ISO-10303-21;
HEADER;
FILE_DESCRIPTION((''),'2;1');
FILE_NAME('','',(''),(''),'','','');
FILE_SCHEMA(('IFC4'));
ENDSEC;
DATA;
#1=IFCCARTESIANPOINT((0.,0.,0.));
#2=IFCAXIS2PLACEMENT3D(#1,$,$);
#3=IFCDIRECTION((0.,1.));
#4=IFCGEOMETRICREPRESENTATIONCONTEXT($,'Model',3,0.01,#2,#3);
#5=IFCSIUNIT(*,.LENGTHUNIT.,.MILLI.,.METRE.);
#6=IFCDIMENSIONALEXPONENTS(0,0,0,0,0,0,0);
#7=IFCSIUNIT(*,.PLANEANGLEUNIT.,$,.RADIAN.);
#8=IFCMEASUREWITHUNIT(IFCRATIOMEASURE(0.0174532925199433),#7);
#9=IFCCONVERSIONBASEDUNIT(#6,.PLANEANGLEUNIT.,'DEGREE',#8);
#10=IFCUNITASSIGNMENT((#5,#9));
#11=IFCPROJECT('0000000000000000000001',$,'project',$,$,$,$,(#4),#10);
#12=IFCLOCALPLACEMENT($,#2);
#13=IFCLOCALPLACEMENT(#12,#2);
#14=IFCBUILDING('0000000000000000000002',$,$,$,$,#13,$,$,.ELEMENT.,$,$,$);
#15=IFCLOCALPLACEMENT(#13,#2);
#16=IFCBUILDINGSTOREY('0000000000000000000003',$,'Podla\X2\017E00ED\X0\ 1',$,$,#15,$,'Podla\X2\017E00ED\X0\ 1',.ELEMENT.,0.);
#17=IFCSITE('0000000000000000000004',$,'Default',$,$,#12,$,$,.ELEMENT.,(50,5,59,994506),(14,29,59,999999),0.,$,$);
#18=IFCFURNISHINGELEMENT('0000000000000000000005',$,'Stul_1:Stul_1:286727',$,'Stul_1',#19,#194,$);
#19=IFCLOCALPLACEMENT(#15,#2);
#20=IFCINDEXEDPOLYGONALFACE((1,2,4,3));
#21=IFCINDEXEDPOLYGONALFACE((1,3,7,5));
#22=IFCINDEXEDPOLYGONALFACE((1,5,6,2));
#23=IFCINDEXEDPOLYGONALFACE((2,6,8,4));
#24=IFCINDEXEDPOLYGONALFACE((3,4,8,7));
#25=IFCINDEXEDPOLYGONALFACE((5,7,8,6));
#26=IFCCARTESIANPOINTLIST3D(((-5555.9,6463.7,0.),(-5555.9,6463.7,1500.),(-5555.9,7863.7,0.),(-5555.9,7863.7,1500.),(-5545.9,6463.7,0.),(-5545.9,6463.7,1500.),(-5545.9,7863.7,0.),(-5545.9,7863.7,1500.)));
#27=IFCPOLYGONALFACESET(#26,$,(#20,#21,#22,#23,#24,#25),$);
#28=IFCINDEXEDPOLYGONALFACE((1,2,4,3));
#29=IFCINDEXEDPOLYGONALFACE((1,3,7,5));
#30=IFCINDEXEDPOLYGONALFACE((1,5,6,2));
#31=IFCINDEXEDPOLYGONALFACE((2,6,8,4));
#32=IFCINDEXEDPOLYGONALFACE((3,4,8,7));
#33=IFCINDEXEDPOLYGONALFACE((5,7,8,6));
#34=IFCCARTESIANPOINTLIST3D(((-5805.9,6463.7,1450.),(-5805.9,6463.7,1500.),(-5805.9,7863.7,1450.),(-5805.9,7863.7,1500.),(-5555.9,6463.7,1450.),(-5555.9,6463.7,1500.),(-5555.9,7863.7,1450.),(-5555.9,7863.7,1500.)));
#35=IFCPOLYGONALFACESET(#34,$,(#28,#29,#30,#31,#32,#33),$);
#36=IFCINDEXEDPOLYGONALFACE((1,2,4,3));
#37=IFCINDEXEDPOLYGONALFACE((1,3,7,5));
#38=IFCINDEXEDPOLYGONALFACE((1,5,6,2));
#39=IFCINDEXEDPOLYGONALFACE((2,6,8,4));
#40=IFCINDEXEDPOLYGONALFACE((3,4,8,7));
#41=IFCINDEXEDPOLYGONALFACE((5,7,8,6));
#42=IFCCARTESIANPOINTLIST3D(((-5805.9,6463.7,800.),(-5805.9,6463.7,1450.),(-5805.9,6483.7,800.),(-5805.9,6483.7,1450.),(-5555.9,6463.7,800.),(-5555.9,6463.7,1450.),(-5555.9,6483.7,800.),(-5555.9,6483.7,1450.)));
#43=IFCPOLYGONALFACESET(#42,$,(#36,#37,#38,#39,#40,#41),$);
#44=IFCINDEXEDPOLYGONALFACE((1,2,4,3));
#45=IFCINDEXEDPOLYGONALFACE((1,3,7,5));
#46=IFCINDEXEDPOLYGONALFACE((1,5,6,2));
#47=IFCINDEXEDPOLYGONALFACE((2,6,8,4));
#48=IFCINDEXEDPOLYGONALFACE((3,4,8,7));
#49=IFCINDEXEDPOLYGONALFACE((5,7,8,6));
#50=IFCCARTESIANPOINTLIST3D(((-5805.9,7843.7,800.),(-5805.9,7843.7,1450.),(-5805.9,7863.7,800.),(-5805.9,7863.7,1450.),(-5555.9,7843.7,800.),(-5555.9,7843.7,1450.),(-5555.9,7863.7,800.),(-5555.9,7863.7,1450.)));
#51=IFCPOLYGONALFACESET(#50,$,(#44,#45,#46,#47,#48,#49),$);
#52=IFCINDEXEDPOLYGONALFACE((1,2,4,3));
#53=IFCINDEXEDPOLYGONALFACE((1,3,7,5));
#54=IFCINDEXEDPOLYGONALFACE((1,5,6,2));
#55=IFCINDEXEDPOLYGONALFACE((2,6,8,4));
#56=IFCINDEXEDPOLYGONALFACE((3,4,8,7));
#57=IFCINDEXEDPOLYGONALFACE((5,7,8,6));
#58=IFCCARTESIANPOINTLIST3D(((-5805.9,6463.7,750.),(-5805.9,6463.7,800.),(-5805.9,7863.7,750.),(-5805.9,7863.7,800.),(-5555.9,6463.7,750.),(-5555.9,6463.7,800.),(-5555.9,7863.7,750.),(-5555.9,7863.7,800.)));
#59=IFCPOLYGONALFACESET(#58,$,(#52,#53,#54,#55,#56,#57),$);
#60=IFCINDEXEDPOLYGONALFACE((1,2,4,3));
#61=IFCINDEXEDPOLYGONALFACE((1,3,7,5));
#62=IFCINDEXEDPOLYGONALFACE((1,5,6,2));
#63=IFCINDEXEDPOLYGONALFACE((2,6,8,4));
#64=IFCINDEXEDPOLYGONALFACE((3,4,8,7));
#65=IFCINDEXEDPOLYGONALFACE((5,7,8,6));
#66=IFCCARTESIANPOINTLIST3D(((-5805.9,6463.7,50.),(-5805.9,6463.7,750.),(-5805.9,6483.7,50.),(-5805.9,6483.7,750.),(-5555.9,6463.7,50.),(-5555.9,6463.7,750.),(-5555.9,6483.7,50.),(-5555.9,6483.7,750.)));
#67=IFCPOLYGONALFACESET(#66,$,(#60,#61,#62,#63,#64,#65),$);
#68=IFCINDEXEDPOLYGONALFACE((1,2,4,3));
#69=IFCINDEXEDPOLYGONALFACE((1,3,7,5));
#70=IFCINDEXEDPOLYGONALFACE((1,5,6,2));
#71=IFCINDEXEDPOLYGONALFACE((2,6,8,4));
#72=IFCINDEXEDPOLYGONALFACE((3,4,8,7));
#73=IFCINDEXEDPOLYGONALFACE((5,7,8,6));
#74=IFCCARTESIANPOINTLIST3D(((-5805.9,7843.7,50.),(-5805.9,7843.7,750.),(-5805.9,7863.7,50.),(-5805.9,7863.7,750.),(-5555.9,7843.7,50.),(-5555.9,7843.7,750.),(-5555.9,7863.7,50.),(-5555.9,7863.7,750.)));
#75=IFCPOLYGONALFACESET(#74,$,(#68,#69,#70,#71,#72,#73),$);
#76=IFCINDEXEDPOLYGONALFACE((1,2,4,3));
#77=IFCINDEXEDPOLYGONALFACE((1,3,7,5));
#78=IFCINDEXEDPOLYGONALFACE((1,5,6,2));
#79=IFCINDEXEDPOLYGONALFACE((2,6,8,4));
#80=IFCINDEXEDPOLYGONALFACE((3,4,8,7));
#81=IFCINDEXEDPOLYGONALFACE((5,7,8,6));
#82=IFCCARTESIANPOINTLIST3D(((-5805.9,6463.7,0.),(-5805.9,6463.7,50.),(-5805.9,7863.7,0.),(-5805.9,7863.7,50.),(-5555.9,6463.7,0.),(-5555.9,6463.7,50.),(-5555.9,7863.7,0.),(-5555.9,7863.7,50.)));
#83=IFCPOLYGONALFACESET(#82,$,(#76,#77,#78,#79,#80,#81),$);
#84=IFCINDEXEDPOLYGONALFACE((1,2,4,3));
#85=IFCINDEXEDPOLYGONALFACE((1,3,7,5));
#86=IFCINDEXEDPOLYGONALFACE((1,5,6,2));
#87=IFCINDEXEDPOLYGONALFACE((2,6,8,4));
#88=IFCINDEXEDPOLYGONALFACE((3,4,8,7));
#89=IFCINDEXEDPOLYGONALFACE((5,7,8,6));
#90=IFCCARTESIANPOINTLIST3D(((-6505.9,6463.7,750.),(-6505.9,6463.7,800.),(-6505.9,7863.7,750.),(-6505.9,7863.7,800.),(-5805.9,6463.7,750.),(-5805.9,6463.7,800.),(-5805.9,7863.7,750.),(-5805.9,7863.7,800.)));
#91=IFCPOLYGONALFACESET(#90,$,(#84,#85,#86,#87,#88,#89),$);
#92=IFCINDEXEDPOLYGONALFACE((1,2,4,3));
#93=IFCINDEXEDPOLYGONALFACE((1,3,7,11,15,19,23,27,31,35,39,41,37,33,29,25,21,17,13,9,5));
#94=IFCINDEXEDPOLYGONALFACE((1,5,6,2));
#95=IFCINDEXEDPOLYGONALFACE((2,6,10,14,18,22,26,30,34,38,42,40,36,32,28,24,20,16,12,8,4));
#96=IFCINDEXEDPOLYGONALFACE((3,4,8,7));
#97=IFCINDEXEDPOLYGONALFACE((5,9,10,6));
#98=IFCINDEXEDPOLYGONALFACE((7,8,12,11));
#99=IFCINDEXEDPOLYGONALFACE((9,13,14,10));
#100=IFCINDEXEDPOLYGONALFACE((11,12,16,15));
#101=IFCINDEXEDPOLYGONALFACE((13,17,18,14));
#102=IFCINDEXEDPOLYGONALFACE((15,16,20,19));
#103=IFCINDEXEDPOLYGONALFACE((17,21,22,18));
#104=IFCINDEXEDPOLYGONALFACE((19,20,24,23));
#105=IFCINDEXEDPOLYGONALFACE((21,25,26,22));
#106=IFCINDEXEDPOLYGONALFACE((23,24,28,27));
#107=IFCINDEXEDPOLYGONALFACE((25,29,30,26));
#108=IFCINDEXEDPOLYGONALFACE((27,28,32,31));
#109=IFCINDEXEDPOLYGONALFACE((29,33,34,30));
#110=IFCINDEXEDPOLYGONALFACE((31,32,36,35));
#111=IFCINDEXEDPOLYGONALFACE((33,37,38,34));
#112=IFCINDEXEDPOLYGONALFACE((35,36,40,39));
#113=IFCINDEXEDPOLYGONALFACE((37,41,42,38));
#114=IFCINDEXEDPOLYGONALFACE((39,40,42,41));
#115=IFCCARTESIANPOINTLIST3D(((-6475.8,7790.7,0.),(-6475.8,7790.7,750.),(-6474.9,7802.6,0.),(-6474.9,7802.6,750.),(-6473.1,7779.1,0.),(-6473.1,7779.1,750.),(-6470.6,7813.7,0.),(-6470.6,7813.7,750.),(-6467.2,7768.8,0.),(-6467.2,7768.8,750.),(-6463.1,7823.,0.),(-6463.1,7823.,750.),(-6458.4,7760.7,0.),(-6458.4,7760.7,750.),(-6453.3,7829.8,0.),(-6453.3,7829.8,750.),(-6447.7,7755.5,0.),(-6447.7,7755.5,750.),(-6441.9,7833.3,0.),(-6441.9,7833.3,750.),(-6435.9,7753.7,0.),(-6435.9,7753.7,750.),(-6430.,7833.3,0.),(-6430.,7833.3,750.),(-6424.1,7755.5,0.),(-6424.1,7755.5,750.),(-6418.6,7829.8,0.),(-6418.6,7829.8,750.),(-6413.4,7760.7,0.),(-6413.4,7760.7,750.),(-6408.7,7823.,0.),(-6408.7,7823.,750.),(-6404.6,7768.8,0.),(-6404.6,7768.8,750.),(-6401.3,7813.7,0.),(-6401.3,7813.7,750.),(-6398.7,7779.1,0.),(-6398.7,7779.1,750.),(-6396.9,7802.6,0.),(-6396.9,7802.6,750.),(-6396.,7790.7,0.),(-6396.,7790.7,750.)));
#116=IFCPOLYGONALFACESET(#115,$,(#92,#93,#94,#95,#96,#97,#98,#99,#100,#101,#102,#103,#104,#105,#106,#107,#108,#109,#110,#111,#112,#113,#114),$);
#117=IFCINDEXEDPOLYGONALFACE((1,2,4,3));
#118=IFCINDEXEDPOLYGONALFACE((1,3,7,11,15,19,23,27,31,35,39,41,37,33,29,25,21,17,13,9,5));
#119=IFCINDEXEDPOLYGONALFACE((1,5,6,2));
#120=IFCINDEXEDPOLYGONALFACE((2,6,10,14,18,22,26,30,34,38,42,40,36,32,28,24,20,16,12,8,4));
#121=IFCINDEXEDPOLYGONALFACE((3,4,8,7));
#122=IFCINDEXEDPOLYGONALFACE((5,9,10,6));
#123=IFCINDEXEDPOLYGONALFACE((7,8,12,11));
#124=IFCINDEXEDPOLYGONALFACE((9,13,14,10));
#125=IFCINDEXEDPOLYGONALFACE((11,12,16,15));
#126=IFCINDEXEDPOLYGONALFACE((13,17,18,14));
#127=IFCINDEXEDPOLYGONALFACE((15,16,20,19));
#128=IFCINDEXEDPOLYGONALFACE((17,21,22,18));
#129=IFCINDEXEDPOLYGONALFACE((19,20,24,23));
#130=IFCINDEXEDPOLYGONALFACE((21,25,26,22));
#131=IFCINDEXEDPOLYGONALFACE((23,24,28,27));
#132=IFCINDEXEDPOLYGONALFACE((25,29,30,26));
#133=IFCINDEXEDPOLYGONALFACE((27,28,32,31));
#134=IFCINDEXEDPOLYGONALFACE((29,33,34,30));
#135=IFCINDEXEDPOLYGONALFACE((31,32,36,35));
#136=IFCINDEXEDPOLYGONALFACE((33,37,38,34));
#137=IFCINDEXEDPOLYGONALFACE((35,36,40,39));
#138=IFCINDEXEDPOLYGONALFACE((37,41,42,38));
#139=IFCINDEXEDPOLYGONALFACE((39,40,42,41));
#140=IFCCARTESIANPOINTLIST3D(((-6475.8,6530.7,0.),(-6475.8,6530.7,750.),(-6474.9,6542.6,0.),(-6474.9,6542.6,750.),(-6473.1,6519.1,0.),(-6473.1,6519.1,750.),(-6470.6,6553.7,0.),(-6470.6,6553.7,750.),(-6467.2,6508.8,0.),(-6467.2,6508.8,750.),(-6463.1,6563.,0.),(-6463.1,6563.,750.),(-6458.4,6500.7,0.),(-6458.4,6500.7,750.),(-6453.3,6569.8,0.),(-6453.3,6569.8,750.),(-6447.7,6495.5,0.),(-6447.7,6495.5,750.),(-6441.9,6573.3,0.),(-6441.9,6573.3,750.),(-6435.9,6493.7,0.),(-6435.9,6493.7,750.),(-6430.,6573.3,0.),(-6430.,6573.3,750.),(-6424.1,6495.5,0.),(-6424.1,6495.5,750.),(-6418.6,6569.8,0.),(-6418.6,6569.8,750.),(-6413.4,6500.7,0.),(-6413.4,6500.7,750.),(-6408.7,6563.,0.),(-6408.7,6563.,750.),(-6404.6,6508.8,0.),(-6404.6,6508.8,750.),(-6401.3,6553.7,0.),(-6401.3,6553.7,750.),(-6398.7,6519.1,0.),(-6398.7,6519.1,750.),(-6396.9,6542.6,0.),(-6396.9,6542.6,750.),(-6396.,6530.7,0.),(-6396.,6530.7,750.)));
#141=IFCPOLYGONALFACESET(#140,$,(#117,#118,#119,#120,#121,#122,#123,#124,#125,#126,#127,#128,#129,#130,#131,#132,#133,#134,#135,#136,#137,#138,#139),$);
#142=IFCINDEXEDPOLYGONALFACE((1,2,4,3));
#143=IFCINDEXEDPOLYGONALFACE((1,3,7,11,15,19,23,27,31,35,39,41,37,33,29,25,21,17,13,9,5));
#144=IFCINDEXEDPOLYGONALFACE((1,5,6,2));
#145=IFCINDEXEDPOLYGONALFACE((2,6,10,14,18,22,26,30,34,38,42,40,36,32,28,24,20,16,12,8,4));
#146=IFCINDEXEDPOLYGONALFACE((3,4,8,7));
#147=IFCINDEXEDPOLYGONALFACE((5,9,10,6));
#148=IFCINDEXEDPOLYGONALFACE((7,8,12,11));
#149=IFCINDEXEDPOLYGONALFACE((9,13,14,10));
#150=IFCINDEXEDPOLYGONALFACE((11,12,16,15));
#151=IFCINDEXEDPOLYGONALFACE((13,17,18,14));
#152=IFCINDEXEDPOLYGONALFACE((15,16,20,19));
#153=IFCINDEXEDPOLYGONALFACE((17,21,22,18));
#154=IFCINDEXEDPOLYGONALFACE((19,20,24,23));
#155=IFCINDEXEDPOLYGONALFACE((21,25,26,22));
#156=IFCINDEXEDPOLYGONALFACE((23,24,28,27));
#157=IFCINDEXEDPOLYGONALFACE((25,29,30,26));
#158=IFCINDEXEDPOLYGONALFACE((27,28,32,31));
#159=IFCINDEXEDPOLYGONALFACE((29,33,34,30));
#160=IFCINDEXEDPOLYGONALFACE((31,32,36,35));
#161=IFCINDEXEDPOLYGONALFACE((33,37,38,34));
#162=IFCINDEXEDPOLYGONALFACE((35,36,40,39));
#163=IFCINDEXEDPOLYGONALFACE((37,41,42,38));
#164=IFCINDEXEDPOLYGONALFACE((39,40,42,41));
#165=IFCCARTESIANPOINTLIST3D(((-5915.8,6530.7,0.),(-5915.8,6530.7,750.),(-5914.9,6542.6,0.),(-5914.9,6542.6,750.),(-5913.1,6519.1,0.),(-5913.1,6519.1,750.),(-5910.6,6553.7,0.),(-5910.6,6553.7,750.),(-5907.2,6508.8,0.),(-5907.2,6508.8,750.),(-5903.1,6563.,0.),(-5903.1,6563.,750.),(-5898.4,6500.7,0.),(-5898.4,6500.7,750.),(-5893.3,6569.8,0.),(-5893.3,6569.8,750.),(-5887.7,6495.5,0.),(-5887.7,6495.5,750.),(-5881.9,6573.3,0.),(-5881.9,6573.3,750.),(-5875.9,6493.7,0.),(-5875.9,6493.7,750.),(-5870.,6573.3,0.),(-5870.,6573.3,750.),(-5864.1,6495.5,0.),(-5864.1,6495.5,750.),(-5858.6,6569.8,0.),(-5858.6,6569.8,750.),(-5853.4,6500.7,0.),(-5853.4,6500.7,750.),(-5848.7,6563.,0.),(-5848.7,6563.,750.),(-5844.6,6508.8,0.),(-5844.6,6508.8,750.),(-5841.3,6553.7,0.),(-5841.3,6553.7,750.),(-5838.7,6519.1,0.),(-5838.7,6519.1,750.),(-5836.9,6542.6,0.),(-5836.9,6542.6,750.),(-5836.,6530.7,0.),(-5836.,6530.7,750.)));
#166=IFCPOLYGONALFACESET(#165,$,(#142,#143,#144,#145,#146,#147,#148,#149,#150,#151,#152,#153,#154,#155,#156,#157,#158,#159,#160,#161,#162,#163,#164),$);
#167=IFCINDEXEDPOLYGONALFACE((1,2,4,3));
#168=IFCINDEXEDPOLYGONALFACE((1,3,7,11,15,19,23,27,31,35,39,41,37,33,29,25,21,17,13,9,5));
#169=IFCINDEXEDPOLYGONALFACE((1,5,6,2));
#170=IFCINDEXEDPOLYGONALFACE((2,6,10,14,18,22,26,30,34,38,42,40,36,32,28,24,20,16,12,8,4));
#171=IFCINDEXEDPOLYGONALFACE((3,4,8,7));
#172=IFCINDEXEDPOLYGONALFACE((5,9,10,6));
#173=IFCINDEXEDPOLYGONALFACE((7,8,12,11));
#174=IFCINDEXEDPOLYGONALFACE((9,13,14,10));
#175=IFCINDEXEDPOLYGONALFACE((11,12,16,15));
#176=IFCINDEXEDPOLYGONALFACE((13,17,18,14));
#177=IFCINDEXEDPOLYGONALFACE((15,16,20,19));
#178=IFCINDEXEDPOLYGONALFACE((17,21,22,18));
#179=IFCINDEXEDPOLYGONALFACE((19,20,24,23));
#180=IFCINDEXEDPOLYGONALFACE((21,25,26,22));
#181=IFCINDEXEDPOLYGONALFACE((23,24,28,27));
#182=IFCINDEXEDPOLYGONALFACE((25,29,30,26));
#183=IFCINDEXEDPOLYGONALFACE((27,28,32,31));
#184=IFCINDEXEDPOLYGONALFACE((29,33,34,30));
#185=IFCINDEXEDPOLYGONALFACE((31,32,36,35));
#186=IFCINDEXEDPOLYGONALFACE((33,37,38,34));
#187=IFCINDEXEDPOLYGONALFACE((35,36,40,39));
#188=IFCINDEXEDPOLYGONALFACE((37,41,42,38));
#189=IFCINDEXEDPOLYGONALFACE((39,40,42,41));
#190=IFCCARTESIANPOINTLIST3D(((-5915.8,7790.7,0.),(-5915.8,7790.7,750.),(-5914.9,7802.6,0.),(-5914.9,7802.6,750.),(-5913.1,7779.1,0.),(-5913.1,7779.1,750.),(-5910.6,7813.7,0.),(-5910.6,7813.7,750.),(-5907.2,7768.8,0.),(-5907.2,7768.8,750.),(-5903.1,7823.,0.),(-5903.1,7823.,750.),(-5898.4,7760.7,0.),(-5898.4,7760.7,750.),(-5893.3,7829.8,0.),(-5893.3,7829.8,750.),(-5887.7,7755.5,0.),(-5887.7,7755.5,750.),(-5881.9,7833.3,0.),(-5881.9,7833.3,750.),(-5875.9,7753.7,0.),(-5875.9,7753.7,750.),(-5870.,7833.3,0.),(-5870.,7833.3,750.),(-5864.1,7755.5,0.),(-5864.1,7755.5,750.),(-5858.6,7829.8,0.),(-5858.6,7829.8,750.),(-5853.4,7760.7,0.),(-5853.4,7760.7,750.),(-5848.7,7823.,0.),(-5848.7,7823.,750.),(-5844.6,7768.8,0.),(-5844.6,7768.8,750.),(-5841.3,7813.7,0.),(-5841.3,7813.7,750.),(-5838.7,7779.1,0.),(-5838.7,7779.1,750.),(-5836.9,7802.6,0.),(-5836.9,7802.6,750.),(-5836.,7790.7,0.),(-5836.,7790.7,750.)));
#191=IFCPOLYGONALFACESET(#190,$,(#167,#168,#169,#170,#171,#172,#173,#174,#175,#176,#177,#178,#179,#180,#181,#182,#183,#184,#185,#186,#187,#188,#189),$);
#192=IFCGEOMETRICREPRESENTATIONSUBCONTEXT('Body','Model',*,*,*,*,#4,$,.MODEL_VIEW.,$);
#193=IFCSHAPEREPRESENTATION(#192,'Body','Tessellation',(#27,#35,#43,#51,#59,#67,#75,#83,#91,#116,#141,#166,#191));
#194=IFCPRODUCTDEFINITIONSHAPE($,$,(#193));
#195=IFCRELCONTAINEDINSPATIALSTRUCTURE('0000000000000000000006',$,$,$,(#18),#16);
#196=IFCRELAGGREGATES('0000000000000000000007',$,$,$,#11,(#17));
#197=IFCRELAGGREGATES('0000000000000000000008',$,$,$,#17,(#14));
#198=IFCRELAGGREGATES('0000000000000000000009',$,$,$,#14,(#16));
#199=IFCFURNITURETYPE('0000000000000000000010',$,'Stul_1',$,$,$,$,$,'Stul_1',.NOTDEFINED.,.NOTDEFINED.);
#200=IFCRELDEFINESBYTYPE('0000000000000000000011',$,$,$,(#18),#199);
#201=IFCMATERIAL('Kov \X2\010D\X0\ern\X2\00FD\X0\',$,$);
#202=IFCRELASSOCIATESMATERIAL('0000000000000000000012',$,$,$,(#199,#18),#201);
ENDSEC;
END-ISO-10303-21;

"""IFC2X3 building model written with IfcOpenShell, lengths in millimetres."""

from ifc_helpers import new_model, entity, si_unit, converted_unit, direction, frame, frame_2d, origin, origin_2d_with_axis, place, context, subcontext, project, spatial, rectangle, circle, extrude, source, transform, mapped, material, type_object, type_shapes, element, save


model = new_model("IFC2X3")

# Units and contexts
model_context = context("Model", 3, precision=0.01, world=origin(), true_north=direction((0.0, 1.0)))
body_context = subcontext(model_context, "Body", "Model", "MODEL_VIEW")
ifc_project = project(units=[si_unit("LENGTHUNIT", "METRE", prefix="MILLI"), converted_unit("PLANEANGLEUNIT", "DEGREE", entity("IfcRatioMeasure", 0.0174532925199433), si_unit("PLANEANGLEUNIT", "RADIAN"), dimensions=[0, 0, 0, 0, 0, 0, 0])], contexts=[model_context])

# Site, building, storey
site_placement = place(None, origin())
site = spatial("IfcSite", under=ifc_project, at=site_placement, Name="Default", CompositionType="ELEMENT", RefLatitude=(50, 5, 59, 994506), RefLongitude=(14, 29, 59, 999999), RefElevation=0.0)
building_placement = place(site_placement, origin())
building = spatial("IfcBuilding", under=site, at=building_placement, CompositionType="ELEMENT")
storey_placement = place(building_placement, origin())
storey = spatial("IfcBuildingStorey", under=building, at=storey_placement, Name="Podlaží 1", LongName="Podlaží 1", CompositionType="ELEMENT", Elevation=0.0)

# Furnishing element
ifc_material_1 = material(Name="Kov černý")
furniture_type = type_object("IfcFurnitureType", Name="Stul_1", ElementType="Stul_1", material=ifc_material_1)
shared_shape_1 = source(origin(), body_context, "Body", "SweptSolid", [
    extrude(rectangle(XDim=1400.0, YDim=10.0, at=origin_2d_with_axis()), frame((0.0, 605.0, 0.0), z_axis=(0.0, 0.0, 1.0), x_axis=(-1.0, 0.0, 0.0)), (0.0, 0.0, 1.0), 1500.0),
    extrude(rectangle(XDim=1400.0, YDim=250.0, at=frame_2d((0.0, 0.0), x_axis=(1.0, 0.0))), frame((0.0, 475.0, 1450.0), z_axis=(0.0, 0.0, 1.0), x_axis=(-1.0, 0.0, 0.0)), (0.0, 0.0, 1.0), 50.0),
    extrude(rectangle(XDim=20.0, YDim=250.0, at=origin_2d_with_axis()), frame((690.0, 475.0, 800.0), z_axis=(0.0, 0.0, 1.0), x_axis=(-1.0, 0.0, 0.0)), (0.0, 0.0, 1.0), 650.0),
    extrude(rectangle(XDim=20.0, YDim=250.0, at=frame_2d((0.0, 0.0), x_axis=(1.0, 0.0))), frame((-690.0, 475.0, 800.0), z_axis=(0.0, 0.0, 1.0), x_axis=(-1.0, 0.0, 0.0)), (0.0, 0.0, 1.0), 650.0),
    extrude(rectangle(XDim=1400.0, YDim=250.0, at=origin_2d_with_axis()), frame((0.0, 475.0, 750.0), z_axis=(0.0, 0.0, 1.0), x_axis=(-1.0, 0.0, 0.0)), (0.0, 0.0, 1.0), 50.0),
    extrude(rectangle(XDim=20.0, YDim=250.0, at=origin_2d_with_axis()), frame((690.0, 475.0, 50.0), z_axis=(0.0, 0.0, 1.0), x_axis=(-1.0, 0.0, 0.0)), (0.0, 0.0, 1.0), 700.0),
    extrude(rectangle(XDim=20.0, YDim=250.0, at=frame_2d((0.0, 0.0), x_axis=(1.0, 0.0))), frame((-690.0, 475.0, 50.0), z_axis=(0.0, 0.0, 1.0), x_axis=(-1.0, 0.0, 0.0)), (0.0, 0.0, 1.0), 700.0),
    extrude(rectangle(XDim=1400.0, YDim=250.0, at=origin_2d_with_axis()), frame((0.0, 475.0, 0.0), z_axis=(0.0, 0.0, 1.0), x_axis=(-1.0, 0.0, 0.0)), (0.0, 0.0, 1.0), 50.0),
    extrude(rectangle(XDim=1400.0, YDim=700.0, at=origin_2d_with_axis()), frame((0.0, 0.0, 750.0), z_axis=(0.0, 0.0, 1.0), x_axis=(-1.0, 0.0, 0.0)), (0.0, 0.0, 1.0), 50.0),
    extrude(circle(Radius=40.0, at=frame_2d((0.0, 0.0), x_axis=(1.0, 0.0))), frame((-630.0, -280.0, 0.0)), (0.0, 0.0, 1.0), 750.0),
    extrude(circle(Radius=40.0, at=frame_2d((0.0, 0.0), x_axis=(1.0, 0.0))), frame((630.0, -280.0, 0.0)), (0.0, 0.0, 1.0), 750.0),
    extrude(circle(Radius=40.0, at=frame_2d((0.0, 0.0), x_axis=(1.0, 0.0))), frame((630.0, 280.0, 0.0)), (0.0, 0.0, 1.0), 750.0),
    extrude(circle(Radius=40.0, at=frame_2d((0.0, 0.0), x_axis=(1.0, 0.0))), frame((-630.0, 280.0, 0.0)), (0.0, 0.0, 1.0), 750.0),
])
type_shapes(furniture_type, [shared_shape_1])
for number, where, z_axis, x_axis, name in (
    (1, (-6155.9, 7163.7, 0.0), (0.0, 0.0, 1.0), (0.0, -1.0, 0.0), "Stul_1:Stul_1:286727"),
):
    element("IfcFurnishingElement", number, at=place(storey_placement, frame(where, z_axis=z_axis, x_axis=x_axis)), inside=storey, type_object=furniture_type, material=ifc_material_1, Name=name, ObjectType="Stul_1", context=body_context, shape_type="MappedRepresentation", body=[
        mapped(shared_shape_1, transform((0.0, 0.0, 0.0), scale=1.0)),
    ])

save(model, "model.ifc")
